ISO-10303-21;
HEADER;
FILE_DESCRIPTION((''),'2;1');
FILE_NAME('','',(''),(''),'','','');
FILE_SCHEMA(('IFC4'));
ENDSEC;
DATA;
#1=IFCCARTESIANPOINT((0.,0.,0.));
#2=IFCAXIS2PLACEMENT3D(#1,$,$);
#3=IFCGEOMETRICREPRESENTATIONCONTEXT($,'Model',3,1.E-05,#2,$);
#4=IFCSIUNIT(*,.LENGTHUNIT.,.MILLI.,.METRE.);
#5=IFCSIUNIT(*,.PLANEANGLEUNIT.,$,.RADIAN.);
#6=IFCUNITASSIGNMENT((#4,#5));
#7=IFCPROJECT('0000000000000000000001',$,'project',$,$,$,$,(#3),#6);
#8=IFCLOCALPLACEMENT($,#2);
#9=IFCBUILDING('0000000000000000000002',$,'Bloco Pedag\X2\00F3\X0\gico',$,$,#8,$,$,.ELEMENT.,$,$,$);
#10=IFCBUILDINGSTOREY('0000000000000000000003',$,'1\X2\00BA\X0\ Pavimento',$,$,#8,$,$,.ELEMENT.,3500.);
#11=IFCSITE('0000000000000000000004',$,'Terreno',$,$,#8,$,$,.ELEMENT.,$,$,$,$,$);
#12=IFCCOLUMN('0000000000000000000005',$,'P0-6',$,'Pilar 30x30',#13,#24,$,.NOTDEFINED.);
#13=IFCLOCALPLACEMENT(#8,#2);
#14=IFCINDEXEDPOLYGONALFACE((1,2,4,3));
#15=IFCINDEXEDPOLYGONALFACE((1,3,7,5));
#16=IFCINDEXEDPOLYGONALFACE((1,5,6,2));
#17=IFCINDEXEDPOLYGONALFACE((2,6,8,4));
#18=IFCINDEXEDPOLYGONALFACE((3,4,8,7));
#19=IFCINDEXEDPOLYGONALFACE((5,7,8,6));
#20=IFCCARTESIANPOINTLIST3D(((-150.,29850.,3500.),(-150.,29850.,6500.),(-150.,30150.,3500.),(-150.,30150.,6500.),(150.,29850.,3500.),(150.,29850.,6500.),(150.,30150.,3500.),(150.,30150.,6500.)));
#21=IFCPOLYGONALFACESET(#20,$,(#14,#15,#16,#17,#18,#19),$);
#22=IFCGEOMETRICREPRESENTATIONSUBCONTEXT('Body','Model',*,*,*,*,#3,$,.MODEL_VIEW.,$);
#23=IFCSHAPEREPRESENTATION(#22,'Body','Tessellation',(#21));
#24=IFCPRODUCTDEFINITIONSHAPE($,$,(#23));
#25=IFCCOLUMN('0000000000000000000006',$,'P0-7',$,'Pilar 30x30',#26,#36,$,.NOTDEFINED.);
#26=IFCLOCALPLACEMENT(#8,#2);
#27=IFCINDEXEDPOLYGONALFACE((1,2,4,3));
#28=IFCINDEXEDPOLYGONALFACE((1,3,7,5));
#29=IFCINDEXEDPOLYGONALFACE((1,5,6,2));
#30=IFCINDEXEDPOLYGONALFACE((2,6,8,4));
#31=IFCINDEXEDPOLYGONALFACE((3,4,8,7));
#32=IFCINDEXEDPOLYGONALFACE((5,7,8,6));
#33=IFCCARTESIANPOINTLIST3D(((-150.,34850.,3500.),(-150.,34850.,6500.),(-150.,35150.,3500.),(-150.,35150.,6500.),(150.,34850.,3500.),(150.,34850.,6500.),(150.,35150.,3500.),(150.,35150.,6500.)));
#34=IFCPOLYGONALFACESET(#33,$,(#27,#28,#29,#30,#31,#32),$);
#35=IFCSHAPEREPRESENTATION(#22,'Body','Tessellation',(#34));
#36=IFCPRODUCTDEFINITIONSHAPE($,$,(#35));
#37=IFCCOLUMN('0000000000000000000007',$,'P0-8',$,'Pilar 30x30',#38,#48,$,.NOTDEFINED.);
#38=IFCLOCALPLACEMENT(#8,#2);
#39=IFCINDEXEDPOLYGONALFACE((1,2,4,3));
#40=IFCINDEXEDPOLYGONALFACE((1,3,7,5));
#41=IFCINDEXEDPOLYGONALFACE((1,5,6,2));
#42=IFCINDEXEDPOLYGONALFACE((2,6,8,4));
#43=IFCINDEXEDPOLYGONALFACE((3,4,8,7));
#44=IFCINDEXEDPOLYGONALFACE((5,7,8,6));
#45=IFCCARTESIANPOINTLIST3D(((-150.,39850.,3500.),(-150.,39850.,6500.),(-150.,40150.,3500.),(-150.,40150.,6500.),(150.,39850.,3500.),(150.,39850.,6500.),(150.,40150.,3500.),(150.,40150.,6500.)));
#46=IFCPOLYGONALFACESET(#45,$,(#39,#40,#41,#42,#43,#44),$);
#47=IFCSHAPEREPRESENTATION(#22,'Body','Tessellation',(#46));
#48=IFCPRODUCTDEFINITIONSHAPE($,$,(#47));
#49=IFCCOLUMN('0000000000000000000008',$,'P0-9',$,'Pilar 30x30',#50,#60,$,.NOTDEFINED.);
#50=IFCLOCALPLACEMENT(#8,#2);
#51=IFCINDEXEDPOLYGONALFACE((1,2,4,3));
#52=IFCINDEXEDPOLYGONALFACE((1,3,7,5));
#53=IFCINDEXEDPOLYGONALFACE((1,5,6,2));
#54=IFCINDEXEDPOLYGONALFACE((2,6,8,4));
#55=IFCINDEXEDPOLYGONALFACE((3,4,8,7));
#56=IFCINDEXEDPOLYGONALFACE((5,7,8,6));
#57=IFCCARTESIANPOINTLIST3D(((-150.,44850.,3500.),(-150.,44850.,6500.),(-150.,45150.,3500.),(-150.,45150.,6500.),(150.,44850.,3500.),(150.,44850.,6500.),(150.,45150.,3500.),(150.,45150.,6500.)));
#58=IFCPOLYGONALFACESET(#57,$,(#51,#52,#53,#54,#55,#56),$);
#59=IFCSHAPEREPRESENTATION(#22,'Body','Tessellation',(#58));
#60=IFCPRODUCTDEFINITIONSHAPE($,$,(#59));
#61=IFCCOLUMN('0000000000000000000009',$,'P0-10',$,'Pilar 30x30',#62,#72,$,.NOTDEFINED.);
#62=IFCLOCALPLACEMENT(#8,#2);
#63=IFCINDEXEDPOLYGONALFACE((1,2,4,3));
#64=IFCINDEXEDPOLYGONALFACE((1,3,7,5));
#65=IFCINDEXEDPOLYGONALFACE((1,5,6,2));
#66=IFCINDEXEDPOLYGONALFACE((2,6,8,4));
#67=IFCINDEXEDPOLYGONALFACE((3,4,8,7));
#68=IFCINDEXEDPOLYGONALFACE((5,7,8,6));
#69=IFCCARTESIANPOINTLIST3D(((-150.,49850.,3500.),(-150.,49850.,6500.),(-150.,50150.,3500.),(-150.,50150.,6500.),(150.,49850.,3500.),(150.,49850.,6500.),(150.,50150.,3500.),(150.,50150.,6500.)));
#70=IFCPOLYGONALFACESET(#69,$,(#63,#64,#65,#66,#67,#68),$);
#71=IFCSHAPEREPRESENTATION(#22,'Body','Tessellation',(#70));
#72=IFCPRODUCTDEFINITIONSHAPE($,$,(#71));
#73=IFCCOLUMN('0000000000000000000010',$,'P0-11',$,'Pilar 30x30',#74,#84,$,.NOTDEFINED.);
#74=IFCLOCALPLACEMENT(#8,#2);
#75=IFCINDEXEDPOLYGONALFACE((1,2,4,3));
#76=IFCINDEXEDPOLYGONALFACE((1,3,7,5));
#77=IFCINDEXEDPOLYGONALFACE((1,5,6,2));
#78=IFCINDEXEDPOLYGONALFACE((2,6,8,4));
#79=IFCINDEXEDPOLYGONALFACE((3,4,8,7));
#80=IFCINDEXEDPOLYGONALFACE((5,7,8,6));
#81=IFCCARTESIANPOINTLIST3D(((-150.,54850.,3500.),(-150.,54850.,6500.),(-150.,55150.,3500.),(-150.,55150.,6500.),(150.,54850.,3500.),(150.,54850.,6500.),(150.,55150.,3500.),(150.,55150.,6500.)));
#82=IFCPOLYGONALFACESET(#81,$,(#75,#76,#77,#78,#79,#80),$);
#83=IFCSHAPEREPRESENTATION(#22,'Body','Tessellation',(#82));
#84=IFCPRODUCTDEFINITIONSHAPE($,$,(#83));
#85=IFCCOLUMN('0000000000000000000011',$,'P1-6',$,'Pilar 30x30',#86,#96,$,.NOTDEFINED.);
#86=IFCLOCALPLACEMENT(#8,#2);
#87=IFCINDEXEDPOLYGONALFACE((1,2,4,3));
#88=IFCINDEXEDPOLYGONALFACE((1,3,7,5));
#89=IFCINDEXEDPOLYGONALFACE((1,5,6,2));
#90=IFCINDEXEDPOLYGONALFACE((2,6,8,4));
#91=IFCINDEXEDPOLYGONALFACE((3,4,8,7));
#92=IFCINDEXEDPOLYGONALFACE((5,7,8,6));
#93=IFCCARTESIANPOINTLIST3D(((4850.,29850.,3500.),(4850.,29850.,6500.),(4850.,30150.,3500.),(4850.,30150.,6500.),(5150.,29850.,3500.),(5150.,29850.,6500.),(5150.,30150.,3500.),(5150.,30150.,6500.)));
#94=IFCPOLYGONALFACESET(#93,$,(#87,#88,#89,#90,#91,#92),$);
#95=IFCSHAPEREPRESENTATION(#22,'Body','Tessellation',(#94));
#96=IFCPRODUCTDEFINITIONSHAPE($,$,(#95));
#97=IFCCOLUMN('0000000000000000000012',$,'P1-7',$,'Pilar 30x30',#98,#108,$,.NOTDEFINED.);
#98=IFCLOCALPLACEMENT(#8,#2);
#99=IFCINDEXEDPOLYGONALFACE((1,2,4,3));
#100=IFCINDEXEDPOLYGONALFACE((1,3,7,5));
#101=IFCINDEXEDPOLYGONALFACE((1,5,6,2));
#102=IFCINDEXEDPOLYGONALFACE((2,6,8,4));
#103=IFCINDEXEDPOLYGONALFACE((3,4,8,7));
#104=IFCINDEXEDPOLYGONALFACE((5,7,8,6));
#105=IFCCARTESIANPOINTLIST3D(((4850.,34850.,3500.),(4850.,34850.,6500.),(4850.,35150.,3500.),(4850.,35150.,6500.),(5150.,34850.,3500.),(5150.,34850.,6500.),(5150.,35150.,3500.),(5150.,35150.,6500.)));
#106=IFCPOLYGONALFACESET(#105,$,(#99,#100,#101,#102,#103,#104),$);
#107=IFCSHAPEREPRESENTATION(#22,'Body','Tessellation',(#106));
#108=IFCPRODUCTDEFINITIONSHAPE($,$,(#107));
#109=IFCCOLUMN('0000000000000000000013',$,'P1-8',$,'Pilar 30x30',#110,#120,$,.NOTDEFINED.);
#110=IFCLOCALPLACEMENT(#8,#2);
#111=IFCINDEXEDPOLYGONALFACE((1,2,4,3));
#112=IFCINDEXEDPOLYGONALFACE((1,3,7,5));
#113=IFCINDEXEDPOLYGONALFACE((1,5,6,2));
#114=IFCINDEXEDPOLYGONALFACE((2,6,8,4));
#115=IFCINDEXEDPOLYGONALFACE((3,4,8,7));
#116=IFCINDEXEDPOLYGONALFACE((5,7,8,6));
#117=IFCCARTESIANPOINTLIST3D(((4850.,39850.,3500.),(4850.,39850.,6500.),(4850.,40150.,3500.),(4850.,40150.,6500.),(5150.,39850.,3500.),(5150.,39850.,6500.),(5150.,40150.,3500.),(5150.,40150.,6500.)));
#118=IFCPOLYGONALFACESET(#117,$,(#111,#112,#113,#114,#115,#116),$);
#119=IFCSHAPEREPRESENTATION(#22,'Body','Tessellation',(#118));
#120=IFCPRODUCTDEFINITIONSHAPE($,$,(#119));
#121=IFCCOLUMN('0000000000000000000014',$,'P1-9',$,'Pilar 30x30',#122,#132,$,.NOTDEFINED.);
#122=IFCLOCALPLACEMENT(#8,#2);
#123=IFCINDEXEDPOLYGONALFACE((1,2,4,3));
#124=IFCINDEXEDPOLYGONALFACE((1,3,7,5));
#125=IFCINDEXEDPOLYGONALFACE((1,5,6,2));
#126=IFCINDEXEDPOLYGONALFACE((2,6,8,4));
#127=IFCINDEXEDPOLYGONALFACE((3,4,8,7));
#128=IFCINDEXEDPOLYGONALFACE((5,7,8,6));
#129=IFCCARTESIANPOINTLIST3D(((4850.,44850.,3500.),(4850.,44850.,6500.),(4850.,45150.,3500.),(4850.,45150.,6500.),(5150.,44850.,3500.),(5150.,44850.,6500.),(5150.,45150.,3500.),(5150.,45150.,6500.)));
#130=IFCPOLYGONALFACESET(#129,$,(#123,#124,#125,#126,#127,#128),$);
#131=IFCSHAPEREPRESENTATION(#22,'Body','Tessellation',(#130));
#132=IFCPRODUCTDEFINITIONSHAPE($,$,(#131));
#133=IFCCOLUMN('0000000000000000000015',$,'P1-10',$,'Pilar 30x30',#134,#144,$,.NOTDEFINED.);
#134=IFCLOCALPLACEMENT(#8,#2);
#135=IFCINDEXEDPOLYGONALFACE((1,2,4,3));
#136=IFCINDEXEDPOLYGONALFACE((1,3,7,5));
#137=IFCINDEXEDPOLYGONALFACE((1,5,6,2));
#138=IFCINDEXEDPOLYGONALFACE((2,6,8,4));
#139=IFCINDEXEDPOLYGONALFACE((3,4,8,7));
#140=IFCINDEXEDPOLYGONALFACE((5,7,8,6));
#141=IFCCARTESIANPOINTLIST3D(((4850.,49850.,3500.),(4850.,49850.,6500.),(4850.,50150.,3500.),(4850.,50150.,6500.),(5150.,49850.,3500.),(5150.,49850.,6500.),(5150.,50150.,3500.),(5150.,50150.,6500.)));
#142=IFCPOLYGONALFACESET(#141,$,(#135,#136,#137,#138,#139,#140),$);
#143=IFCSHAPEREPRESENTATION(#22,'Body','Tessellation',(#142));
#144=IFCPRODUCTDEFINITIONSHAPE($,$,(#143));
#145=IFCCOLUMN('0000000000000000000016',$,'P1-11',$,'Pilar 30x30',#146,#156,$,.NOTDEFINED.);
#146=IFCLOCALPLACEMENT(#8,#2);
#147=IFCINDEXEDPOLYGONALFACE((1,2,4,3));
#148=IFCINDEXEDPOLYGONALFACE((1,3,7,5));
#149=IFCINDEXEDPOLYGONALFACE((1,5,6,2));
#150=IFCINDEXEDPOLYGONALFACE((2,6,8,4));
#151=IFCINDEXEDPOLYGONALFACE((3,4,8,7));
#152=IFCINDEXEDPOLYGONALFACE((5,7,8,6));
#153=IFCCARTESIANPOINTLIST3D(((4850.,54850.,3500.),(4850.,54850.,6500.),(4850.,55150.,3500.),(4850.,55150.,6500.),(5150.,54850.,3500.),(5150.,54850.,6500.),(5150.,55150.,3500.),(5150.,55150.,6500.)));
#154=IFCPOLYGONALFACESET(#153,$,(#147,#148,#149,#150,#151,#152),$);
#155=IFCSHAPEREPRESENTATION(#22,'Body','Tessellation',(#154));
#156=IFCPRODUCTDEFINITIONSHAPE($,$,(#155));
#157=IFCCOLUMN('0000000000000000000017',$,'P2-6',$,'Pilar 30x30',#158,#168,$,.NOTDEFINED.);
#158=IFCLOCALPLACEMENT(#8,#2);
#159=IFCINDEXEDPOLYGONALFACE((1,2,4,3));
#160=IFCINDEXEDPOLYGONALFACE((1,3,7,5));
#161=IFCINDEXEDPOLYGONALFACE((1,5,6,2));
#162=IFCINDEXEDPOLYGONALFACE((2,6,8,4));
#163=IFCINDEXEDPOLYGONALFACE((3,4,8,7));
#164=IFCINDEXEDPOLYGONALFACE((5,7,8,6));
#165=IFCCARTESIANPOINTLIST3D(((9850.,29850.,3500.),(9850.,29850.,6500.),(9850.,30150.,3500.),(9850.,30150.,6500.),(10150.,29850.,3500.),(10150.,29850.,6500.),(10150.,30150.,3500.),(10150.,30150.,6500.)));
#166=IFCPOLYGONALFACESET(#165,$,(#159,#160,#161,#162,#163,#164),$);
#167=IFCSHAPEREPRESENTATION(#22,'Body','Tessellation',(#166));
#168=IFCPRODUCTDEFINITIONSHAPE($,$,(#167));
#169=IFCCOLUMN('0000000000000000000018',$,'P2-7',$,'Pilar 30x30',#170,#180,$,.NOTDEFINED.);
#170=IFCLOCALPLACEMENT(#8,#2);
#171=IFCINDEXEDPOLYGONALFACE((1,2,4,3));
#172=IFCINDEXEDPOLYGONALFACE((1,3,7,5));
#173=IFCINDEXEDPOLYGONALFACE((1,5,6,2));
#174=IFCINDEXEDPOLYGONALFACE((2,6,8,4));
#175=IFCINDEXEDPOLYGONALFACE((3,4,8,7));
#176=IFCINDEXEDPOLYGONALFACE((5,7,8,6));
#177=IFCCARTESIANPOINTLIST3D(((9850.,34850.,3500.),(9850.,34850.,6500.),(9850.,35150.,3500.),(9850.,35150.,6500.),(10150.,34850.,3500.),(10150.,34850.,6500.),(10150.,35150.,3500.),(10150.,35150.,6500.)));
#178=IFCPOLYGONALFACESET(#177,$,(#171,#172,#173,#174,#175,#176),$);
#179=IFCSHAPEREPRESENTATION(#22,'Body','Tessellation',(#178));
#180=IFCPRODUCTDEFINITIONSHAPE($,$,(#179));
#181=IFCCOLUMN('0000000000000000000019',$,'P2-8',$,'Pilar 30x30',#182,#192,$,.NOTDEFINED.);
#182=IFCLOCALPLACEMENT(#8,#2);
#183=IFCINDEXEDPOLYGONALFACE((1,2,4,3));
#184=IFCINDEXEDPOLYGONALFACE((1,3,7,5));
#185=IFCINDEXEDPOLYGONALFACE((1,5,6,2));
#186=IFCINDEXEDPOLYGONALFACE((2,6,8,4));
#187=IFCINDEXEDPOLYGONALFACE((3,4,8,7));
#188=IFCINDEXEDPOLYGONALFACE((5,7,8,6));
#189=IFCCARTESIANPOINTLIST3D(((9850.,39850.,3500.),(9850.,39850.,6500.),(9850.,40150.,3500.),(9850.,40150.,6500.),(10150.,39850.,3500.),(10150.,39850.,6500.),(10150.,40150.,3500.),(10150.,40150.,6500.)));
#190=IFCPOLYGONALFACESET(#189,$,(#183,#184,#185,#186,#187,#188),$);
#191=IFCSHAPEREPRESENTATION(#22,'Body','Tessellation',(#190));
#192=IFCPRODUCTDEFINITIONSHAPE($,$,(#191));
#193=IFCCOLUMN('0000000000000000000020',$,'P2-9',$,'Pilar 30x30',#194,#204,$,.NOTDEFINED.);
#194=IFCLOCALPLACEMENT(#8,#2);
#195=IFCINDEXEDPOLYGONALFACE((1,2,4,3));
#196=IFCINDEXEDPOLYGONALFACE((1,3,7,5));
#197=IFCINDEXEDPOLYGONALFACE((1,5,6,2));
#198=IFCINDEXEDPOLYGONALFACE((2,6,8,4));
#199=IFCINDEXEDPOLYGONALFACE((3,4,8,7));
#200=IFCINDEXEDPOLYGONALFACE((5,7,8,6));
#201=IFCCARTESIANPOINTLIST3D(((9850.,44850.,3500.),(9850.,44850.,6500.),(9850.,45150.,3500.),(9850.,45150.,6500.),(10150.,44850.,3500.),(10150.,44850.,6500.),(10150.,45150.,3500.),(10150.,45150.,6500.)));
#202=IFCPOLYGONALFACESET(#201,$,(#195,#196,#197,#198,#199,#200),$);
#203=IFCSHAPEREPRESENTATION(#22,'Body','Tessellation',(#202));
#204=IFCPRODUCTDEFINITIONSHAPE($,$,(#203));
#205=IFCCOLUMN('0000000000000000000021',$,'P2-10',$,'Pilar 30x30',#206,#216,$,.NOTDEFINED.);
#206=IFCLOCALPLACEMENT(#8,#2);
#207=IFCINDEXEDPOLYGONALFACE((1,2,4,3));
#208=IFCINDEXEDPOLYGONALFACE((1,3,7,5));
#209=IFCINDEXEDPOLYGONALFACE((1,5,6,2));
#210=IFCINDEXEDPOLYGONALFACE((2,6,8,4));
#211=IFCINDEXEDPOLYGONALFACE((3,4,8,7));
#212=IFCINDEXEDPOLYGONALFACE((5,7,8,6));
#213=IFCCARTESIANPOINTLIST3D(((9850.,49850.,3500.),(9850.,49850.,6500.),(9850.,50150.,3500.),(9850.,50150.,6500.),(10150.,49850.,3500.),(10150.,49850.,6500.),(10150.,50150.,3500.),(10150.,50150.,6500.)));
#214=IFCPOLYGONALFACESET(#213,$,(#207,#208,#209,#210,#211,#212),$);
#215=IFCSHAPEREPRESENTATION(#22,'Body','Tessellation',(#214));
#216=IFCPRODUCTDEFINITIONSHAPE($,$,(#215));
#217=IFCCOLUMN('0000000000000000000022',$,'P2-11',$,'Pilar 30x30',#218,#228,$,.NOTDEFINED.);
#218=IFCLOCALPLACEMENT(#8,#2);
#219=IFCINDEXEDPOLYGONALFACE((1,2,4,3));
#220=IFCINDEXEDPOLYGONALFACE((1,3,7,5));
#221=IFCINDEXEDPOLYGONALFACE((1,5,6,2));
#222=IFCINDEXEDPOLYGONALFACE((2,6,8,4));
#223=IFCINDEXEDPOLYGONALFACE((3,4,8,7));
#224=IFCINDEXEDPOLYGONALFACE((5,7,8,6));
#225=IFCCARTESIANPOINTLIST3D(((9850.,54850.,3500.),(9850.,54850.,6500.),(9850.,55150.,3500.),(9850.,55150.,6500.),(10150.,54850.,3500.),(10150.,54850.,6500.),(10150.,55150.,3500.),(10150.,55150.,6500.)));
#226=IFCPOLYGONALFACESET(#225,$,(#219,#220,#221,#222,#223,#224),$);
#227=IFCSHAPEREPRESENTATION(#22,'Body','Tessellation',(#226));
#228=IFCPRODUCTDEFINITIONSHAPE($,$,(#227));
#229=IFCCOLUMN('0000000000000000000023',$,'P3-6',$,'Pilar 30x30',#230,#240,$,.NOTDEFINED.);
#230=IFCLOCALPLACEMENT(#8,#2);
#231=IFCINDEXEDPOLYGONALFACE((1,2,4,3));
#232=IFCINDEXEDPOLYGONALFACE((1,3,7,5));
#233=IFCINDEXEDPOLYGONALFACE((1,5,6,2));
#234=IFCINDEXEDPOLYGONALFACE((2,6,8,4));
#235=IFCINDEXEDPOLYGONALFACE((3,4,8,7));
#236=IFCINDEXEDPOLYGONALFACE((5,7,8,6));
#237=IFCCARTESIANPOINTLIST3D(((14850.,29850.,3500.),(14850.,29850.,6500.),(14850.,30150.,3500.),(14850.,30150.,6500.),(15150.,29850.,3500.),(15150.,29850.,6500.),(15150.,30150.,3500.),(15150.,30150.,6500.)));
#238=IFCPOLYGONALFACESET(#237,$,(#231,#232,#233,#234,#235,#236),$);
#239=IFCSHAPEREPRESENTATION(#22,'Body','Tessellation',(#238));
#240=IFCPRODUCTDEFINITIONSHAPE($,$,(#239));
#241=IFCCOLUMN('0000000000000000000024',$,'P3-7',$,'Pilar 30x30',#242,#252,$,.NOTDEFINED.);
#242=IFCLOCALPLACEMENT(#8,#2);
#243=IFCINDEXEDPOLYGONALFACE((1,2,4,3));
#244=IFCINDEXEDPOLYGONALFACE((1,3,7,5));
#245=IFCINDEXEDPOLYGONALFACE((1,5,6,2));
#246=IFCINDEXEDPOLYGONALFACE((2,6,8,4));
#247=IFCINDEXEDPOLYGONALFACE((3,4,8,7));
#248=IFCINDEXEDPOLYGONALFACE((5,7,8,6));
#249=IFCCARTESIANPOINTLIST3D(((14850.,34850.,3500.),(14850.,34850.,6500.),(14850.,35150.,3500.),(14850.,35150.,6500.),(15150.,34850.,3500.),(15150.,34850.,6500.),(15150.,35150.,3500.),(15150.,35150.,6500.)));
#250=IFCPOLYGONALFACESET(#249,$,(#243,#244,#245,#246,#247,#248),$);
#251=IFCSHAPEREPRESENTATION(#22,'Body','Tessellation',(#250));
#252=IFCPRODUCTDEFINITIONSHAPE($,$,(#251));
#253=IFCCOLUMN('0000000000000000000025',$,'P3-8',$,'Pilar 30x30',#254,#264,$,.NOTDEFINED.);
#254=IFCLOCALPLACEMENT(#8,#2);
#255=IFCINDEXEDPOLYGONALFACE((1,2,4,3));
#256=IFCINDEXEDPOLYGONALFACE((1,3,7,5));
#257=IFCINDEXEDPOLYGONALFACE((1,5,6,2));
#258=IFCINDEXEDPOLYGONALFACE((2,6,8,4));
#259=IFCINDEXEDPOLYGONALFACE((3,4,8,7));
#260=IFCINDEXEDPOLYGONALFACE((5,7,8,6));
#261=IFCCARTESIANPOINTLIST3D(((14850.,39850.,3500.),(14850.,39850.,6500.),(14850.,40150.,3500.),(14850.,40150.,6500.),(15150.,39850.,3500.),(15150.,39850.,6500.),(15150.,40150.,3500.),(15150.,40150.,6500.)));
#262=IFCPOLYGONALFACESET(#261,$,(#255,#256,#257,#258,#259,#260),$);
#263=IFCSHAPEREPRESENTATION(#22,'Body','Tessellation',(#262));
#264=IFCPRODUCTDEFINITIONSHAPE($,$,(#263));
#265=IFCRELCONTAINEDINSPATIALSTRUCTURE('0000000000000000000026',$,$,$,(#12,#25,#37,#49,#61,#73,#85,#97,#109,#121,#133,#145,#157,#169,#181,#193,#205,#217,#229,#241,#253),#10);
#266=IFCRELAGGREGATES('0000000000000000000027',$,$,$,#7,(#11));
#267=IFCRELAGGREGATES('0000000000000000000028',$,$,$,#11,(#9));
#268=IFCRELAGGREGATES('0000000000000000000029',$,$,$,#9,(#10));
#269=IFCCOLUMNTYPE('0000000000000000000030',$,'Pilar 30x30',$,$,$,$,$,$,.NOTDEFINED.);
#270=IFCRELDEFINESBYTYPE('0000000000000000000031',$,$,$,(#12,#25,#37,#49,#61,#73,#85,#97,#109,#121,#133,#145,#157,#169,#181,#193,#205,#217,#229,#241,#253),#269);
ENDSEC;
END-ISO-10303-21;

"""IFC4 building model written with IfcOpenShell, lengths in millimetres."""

from ifc_helpers import new_model, si_unit, frame, origin, origin_2d, place, context, subcontext, project, spatial, rectangle, extrude, type_object, element, save


model = new_model("IFC4")

# Units and contexts
model_context = context("Model", 3, precision=1e-05, world=origin())
body_context = subcontext(model_context, "Body", "Model", "MODEL_VIEW")
ifc_project = project(units=[si_unit("LENGTHUNIT", "METRE", prefix="MILLI"), si_unit("PLANEANGLEUNIT", "RADIAN")], contexts=[model_context])

# Site, building, storey
placement = place(None, origin())
site = spatial("IfcSite", under=ifc_project, at=placement, Name="Terreno", CompositionType="ELEMENT")
building = spatial("IfcBuilding", under=site, at=placement, Name="Bloco Pedagógico", CompositionType="ELEMENT")
storey = spatial("IfcBuildingStorey", under=building, at=placement, Name="1º Pavimento", CompositionType="ELEMENT", Elevation=3500.0)

# Columns
column_type = type_object("IfcColumnType", Name="Pilar 30x30", PredefinedType="NOTDEFINED")
for number, where, z_axis, x_axis, name in (
    (1, (0.0, 30000.0, 3500.0), (0.0, 0.0, 1.0), (1.0, 0.0, 0.0), "P0-6"),
    (2, (0.0, 35000.0, 3500.0), (0.0, 0.0, 1.0), (1.0, 0.0, 0.0), "P0-7"),
    (3, (0.0, 40000.0, 3500.0), (0.0, 0.0, 1.0), (1.0, 0.0, 0.0), "P0-8"),
    (4, (0.0, 45000.0, 3500.0), (0.0, 0.0, 1.0), (1.0, 0.0, 0.0), "P0-9"),
    (5, (0.0, 50000.0, 3500.0), (0.0, 0.0, 1.0), (1.0, 0.0, 0.0), "P0-10"),
    (6, (0.0, 55000.0, 3500.0), (0.0, 0.0, 1.0), (1.0, 0.0, 0.0), "P0-11"),
    (7, (5000.0, 30000.0, 3500.0), (0.0, 0.0, 1.0), (1.0, 0.0, 0.0), "P1-6"),
    (8, (5000.0, 35000.0, 3500.0), (0.0, 0.0, 1.0), (1.0, 0.0, 0.0), "P1-7"),
    (9, (5000.0, 40000.0, 3500.0), (0.0, 0.0, 1.0), (1.0, 0.0, 0.0), "P1-8"),
    (10, (5000.0, 45000.0, 3500.0), (0.0, 0.0, 1.0), (1.0, 0.0, 0.0), "P1-9"),
    (11, (5000.0, 50000.0, 3500.0), (0.0, 0.0, 1.0), (1.0, 0.0, 0.0), "P1-10"),
    (12, (5000.0, 55000.0, 3500.0), (0.0, 0.0, 1.0), (1.0, 0.0, 0.0), "P1-11"),
    (13, (10000.0, 30000.0, 3500.0), (0.0, 0.0, 1.0), (1.0, 0.0, 0.0), "P2-6"),
    (14, (10000.0, 35000.0, 3500.0), (0.0, 0.0, 1.0), (1.0, 0.0, 0.0), "P2-7"),
    (15, (10000.0, 40000.0, 3500.0), (0.0, 0.0, 1.0), (1.0, 0.0, 0.0), "P2-8"),
    (16, (10000.0, 45000.0, 3500.0), (0.0, 0.0, 1.0), (1.0, 0.0, 0.0), "P2-9"),
    (17, (10000.0, 50000.0, 3500.0), (0.0, 0.0, 1.0), (1.0, 0.0, 0.0), "P2-10"),
    (18, (10000.0, 55000.0, 3500.0), (0.0, 0.0, 1.0), (1.0, 0.0, 0.0), "P2-11"),
    (19, (15000.0, 30000.0, 3500.0), (0.0, 0.0, 1.0), (1.0, 0.0, 0.0), "P3-6"),
    (20, (15000.0, 35000.0, 3500.0), (0.0, 0.0, 1.0), (1.0, 0.0, 0.0), "P3-7"),
    (21, (15000.0, 40000.0, 3500.0), (0.0, 0.0, 1.0), (1.0, 0.0, 0.0), "P3-8"),
):
    element("IfcColumn", number, at=place(None, frame(where, z_axis=z_axis, x_axis=x_axis)), inside=storey, type_object=column_type, Name=name, ObjectType="Pilar 30x30", PredefinedType="NOTDEFINED", context=body_context, shape_type="SweptSolid", body=[
        extrude(rectangle(XDim=300.0, YDim=300.0, at=origin_2d()), None, (0.0, 0.0, 1.0), 3000.0),
    ])

save(model, "model.ifc")
